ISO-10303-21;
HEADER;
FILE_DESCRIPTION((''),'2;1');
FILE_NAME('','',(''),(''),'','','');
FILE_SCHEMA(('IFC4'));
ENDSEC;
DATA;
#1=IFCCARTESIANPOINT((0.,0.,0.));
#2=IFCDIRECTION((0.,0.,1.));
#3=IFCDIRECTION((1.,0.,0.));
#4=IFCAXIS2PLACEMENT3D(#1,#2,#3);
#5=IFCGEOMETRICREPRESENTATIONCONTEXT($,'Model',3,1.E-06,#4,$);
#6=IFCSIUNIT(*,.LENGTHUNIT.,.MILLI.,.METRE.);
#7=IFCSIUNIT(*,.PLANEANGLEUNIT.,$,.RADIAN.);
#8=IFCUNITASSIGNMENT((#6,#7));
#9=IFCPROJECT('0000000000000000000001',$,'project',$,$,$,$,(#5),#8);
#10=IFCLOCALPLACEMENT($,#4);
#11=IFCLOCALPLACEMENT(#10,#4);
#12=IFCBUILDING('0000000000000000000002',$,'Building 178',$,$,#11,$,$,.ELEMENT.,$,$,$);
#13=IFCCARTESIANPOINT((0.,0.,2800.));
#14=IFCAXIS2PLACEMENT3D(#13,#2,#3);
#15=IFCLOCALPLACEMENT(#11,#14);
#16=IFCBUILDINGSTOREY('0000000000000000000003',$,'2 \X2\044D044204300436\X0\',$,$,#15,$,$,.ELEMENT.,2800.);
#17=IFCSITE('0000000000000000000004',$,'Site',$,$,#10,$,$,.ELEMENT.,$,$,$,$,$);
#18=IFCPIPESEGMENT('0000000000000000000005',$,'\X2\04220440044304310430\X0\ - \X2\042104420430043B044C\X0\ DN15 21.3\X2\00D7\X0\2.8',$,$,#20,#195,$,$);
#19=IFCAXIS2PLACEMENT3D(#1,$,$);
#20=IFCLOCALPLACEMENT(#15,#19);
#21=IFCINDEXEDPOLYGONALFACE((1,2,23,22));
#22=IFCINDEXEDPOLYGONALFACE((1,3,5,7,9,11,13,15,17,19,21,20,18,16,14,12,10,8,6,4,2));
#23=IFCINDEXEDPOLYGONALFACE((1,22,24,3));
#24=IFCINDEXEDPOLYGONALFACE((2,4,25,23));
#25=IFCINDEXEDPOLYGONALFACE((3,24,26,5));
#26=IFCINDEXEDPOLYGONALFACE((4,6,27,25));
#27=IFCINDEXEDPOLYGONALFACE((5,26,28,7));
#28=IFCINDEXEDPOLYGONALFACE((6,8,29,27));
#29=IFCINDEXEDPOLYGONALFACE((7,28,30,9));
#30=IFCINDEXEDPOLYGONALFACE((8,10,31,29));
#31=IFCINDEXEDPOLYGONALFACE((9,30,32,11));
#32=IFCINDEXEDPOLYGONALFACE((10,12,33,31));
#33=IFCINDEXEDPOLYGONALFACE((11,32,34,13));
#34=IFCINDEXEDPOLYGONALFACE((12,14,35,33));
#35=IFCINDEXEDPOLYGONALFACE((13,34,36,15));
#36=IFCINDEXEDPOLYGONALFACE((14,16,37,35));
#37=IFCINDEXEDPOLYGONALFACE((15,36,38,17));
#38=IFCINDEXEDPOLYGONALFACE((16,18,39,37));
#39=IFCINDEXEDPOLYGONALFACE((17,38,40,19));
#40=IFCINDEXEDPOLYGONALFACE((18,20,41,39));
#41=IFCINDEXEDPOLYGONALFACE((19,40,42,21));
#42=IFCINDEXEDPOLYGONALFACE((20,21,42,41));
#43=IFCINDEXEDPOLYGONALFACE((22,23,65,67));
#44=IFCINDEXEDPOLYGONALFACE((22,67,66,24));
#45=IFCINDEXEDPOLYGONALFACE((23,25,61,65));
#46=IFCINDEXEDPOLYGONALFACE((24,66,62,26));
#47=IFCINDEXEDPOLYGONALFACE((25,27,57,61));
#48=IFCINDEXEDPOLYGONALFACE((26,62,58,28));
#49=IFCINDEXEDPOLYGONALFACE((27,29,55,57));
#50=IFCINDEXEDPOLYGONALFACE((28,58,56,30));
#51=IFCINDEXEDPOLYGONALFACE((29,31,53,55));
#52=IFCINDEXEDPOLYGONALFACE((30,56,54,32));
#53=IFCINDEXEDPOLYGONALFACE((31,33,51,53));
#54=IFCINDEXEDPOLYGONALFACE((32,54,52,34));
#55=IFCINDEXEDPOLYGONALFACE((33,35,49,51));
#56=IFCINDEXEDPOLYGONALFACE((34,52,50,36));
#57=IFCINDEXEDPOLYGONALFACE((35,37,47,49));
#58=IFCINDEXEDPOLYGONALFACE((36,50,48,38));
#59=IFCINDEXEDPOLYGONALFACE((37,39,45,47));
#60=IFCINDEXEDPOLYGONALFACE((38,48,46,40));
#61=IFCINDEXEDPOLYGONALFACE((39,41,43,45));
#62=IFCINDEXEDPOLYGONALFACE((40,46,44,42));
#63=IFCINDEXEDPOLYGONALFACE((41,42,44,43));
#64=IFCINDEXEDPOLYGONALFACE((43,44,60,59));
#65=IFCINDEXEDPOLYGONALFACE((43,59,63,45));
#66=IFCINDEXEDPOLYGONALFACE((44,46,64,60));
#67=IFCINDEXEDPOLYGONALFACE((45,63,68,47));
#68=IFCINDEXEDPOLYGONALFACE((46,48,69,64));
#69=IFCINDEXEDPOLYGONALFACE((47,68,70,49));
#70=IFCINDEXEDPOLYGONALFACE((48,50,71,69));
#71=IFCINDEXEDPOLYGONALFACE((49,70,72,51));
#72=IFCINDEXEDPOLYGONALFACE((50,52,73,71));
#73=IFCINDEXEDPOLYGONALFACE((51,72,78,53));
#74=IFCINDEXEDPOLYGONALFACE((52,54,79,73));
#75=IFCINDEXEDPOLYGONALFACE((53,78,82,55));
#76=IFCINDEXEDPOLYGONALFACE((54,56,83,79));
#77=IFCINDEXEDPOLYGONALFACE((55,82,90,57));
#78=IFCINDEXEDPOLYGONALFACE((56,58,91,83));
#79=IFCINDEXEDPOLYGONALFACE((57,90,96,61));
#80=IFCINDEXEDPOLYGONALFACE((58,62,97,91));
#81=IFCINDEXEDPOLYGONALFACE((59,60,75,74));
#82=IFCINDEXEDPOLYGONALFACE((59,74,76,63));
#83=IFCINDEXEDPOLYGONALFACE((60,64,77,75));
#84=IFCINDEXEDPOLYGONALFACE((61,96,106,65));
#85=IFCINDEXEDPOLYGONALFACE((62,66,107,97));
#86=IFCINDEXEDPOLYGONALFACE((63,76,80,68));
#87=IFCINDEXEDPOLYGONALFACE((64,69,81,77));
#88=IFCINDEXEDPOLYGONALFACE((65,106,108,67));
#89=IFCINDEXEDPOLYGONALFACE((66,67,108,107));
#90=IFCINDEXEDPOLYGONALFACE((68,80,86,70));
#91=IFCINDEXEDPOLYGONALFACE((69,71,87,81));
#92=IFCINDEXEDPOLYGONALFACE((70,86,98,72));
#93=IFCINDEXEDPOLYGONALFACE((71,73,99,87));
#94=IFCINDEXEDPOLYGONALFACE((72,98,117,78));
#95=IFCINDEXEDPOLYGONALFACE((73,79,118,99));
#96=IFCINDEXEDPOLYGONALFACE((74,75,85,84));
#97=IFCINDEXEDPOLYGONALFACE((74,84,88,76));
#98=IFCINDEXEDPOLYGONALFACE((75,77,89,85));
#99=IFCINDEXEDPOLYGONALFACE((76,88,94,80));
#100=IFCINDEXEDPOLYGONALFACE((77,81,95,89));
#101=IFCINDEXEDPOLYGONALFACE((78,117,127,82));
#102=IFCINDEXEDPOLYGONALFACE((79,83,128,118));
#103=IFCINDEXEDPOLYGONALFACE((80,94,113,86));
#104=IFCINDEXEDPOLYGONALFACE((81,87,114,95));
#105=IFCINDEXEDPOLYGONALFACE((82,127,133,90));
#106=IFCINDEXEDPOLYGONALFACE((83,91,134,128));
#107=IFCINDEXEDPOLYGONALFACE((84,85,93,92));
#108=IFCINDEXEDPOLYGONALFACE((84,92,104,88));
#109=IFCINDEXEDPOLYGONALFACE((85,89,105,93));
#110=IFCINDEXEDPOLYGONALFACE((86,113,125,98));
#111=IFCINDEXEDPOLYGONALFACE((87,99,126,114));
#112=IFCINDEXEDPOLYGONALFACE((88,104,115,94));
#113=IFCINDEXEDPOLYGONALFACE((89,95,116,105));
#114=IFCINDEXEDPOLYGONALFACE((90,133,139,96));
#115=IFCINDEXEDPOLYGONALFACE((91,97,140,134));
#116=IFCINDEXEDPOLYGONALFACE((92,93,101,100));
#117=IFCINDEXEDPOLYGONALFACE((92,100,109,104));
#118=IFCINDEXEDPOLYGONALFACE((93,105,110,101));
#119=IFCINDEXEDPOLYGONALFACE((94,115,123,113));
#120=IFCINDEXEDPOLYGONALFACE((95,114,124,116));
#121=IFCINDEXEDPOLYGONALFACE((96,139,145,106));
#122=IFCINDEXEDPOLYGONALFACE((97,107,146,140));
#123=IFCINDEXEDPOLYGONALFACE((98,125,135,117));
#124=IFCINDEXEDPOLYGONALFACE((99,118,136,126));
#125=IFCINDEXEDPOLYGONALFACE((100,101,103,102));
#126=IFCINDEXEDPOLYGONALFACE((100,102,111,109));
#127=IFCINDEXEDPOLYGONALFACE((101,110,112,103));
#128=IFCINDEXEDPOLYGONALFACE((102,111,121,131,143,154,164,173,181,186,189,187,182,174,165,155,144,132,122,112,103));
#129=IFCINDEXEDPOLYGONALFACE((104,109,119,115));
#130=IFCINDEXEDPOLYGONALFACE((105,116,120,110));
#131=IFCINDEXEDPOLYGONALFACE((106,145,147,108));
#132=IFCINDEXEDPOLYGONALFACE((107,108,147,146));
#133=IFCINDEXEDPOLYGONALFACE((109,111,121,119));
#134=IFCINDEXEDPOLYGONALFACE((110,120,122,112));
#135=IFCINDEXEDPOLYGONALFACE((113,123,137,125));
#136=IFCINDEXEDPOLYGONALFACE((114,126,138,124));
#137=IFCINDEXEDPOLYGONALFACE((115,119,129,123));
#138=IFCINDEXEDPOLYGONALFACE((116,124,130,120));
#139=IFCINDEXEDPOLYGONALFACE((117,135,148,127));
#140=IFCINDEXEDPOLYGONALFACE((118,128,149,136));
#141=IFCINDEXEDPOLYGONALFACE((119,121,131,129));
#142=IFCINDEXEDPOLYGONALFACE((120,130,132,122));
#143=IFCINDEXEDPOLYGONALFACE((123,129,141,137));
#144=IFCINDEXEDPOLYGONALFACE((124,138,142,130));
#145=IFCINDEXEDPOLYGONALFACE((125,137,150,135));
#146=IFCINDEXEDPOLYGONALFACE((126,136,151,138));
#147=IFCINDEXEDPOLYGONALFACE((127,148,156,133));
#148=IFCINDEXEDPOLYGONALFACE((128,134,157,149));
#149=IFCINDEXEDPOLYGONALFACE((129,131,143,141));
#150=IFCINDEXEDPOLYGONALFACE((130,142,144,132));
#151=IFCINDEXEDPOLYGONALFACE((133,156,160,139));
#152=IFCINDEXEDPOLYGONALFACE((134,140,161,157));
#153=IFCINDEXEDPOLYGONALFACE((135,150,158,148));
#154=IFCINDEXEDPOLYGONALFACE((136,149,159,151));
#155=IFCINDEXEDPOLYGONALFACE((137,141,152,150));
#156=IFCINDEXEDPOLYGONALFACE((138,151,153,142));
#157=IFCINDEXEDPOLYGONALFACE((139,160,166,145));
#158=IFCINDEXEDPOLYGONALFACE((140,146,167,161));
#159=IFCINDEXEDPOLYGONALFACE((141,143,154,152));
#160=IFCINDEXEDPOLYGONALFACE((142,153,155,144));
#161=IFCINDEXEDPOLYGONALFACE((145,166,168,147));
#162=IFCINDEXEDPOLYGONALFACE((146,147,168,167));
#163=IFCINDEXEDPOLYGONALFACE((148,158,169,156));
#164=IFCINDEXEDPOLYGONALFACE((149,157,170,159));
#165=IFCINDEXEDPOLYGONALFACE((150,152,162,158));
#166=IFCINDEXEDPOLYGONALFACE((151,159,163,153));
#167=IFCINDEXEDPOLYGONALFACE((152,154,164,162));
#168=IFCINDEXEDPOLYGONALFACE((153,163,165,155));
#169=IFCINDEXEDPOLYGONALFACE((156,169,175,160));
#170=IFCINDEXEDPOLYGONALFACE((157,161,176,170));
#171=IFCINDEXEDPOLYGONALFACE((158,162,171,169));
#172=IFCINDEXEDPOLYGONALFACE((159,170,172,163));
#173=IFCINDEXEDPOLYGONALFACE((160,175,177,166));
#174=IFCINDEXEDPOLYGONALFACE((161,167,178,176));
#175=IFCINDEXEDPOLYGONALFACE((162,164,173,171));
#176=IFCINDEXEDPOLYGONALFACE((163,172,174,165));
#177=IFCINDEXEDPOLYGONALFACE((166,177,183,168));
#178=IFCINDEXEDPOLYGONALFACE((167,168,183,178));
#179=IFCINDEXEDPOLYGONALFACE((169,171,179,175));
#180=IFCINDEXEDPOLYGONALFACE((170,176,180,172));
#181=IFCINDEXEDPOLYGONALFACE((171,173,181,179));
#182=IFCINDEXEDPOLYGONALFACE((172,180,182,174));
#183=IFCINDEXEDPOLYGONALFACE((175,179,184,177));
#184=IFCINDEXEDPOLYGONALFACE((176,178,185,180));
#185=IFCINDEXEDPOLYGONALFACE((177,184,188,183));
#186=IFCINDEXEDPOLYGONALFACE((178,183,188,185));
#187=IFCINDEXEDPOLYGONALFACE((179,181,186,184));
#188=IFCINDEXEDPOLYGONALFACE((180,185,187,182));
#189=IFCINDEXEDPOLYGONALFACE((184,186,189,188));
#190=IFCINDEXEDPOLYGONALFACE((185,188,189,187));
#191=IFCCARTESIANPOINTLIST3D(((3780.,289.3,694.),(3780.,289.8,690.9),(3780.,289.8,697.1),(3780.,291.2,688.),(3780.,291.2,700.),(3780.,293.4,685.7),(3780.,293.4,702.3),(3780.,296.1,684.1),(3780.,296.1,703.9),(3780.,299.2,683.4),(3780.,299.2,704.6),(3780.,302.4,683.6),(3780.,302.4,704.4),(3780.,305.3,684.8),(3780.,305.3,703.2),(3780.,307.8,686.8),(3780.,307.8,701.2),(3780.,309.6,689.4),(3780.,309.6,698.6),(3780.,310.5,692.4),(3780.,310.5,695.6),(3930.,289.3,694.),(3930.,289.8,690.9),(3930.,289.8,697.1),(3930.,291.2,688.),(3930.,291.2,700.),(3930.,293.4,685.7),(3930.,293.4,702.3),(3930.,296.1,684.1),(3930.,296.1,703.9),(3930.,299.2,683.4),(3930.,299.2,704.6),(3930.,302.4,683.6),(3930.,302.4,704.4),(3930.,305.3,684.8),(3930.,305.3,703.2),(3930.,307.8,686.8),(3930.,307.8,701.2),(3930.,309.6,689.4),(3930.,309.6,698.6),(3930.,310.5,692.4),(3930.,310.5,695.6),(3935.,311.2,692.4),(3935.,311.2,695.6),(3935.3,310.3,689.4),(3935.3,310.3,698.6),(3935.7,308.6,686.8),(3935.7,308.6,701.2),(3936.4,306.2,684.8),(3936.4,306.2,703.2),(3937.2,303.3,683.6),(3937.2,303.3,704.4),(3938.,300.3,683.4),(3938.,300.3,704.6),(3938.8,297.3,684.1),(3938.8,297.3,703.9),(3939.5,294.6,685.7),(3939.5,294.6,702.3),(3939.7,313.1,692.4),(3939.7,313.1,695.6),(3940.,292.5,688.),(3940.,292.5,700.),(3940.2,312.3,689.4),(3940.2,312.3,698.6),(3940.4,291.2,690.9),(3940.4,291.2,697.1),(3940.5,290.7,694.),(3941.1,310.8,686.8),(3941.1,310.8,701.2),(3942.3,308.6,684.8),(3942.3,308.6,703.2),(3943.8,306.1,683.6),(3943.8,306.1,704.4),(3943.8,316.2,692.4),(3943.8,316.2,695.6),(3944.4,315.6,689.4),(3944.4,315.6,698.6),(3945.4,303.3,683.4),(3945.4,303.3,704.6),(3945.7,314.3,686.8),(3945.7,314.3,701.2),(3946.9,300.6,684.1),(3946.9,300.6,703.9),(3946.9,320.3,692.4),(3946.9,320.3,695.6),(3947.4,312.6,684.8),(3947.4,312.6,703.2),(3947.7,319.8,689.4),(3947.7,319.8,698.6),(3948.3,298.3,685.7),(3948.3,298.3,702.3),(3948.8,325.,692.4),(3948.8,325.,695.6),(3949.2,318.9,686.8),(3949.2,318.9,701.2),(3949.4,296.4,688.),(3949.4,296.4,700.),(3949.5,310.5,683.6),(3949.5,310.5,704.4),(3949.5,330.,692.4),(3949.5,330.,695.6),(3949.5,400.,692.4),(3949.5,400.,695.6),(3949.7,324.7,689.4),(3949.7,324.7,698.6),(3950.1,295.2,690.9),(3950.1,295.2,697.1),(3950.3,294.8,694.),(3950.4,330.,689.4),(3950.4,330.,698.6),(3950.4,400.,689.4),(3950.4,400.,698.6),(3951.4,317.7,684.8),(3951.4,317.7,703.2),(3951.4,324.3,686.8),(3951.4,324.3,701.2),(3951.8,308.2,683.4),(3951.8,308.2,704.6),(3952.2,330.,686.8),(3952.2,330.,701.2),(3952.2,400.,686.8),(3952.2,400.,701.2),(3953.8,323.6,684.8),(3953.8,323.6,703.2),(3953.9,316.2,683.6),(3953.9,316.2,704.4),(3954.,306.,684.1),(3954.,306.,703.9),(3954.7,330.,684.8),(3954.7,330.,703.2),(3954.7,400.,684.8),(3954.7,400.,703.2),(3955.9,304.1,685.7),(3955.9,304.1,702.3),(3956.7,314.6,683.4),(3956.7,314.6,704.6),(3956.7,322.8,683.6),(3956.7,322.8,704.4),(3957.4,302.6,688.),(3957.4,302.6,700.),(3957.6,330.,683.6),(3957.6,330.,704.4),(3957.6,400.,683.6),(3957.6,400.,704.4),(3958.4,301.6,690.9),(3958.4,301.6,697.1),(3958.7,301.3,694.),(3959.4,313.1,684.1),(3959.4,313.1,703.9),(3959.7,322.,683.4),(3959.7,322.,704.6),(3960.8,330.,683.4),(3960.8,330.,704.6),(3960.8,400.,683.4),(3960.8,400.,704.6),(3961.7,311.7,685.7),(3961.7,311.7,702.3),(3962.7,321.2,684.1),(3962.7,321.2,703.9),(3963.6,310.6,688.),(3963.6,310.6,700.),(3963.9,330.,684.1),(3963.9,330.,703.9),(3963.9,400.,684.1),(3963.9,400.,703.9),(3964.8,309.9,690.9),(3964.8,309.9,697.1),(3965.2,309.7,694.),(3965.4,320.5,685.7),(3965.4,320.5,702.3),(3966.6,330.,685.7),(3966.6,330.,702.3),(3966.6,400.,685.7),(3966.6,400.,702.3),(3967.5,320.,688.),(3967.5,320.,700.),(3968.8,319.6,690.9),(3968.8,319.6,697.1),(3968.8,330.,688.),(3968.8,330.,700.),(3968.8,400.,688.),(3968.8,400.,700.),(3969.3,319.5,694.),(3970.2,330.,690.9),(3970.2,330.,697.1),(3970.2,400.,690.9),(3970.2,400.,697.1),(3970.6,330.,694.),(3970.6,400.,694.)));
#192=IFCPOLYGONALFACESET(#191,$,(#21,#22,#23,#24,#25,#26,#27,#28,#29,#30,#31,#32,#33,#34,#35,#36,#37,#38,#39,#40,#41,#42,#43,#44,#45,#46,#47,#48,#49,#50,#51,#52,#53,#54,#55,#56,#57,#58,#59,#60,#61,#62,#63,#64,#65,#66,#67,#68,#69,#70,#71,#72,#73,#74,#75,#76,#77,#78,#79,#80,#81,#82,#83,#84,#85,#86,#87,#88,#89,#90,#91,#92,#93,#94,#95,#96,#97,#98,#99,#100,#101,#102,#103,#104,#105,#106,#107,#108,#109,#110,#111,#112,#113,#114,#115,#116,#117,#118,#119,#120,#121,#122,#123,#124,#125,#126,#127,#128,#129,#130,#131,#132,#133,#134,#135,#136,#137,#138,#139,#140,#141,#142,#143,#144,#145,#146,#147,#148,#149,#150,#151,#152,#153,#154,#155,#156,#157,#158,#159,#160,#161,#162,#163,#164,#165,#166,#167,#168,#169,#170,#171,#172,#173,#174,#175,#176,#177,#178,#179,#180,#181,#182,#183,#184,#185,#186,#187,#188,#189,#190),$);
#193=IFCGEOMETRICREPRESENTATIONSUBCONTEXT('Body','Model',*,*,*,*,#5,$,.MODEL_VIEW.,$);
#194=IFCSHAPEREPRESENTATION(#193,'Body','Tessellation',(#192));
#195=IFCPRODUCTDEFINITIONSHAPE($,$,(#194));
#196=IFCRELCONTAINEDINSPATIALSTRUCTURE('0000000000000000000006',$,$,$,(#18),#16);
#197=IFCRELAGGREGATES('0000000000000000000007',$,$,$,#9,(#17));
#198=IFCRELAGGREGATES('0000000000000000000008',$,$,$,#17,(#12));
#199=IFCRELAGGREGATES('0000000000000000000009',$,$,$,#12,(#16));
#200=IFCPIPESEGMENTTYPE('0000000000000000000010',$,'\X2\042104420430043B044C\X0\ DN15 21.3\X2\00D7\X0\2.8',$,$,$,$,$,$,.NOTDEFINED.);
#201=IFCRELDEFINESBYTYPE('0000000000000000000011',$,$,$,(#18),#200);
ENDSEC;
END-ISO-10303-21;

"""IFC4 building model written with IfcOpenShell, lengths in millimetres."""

from ifc_helpers import new_model, entity, si_unit, frame, origin_with_axes, place, context, subcontext, project, spatial, source, transform, mapped, type_object, element, save


model = new_model("IFC4")

# Units and contexts
model_context = context("Model", 3, precision=1e-06, world=origin_with_axes())
body_context = subcontext(model_context, "Body", "Model", "MODEL_VIEW")
ifc_project = project(units=[si_unit("LENGTHUNIT", "METRE", prefix="MILLI"), si_unit("PLANEANGLEUNIT", "RADIAN")], contexts=[model_context])

# Site, building, storey
site_placement = place(None, origin_with_axes())
site = spatial("IfcSite", under=ifc_project, at=site_placement, Name="Site", CompositionType="ELEMENT")
building_placement = place(site_placement, origin_with_axes())
building = spatial("IfcBuilding", under=site, at=building_placement, Name="Building 178", CompositionType="ELEMENT")
storey_placement = place(building_placement, frame((0.0, 0.0, 2800.0), z_axis=(0.0, 0.0, 1.0), x_axis=(1.0, 0.0, 0.0)))
storey = spatial("IfcBuildingStorey", under=building, at=storey_placement, Name="2 этаж", CompositionType="ELEMENT", Elevation=2800.0)

# Pipe segment
pipe_segment_type = type_object("IfcPipeSegmentType", Name="Сталь DN15 21.3×2.8", PredefinedType="NOTDEFINED")
shared_shape_1 = source(origin_with_axes(), body_context, "Body", "AdvancedSweptSolid", [
    entity("IfcSweptDiskSolid", entity("IfcIndexedPolyCurve", entity("IfcCartesianPointList3D", [[0.0, 0.0, 0.0], [0.0, 0.0, -70.0], [8.8, 0.0, -91.2], [30.0, 0.0, -100.0], [180.0, 0.0, -100.0]]), [entity("IfcLineIndex", [1, 2]), entity("IfcArcIndex", [2, 3, 4]), entity("IfcLineIndex", [4, 5])]), 10.7),
])
for number, where, z_axis, x_axis, name in (
    (1, (3960.0, 400.0, 694.0), (0.0, 1.0, 0.0), (-1.0, 0.0, 0.0), "Труба - Сталь DN15 21.3×2.8"),
):
    element("IfcPipeSegment", number, at=place(storey_placement, frame(where, z_axis=z_axis, x_axis=x_axis)), inside=storey, type_object=pipe_segment_type, Name=name, context=body_context, shape_type="MappedRepresentation", body=[
        mapped(shared_shape_1, transform((0.0, 0.0, 0.0), x_axis=(1.0, 0.0, 0.0), y_axis=(0.0, 1.0, 0.0), z_axis=(0.0, 0.0, 1.0), scale=1.0)),
    ])

save(model, "model.ifc")
